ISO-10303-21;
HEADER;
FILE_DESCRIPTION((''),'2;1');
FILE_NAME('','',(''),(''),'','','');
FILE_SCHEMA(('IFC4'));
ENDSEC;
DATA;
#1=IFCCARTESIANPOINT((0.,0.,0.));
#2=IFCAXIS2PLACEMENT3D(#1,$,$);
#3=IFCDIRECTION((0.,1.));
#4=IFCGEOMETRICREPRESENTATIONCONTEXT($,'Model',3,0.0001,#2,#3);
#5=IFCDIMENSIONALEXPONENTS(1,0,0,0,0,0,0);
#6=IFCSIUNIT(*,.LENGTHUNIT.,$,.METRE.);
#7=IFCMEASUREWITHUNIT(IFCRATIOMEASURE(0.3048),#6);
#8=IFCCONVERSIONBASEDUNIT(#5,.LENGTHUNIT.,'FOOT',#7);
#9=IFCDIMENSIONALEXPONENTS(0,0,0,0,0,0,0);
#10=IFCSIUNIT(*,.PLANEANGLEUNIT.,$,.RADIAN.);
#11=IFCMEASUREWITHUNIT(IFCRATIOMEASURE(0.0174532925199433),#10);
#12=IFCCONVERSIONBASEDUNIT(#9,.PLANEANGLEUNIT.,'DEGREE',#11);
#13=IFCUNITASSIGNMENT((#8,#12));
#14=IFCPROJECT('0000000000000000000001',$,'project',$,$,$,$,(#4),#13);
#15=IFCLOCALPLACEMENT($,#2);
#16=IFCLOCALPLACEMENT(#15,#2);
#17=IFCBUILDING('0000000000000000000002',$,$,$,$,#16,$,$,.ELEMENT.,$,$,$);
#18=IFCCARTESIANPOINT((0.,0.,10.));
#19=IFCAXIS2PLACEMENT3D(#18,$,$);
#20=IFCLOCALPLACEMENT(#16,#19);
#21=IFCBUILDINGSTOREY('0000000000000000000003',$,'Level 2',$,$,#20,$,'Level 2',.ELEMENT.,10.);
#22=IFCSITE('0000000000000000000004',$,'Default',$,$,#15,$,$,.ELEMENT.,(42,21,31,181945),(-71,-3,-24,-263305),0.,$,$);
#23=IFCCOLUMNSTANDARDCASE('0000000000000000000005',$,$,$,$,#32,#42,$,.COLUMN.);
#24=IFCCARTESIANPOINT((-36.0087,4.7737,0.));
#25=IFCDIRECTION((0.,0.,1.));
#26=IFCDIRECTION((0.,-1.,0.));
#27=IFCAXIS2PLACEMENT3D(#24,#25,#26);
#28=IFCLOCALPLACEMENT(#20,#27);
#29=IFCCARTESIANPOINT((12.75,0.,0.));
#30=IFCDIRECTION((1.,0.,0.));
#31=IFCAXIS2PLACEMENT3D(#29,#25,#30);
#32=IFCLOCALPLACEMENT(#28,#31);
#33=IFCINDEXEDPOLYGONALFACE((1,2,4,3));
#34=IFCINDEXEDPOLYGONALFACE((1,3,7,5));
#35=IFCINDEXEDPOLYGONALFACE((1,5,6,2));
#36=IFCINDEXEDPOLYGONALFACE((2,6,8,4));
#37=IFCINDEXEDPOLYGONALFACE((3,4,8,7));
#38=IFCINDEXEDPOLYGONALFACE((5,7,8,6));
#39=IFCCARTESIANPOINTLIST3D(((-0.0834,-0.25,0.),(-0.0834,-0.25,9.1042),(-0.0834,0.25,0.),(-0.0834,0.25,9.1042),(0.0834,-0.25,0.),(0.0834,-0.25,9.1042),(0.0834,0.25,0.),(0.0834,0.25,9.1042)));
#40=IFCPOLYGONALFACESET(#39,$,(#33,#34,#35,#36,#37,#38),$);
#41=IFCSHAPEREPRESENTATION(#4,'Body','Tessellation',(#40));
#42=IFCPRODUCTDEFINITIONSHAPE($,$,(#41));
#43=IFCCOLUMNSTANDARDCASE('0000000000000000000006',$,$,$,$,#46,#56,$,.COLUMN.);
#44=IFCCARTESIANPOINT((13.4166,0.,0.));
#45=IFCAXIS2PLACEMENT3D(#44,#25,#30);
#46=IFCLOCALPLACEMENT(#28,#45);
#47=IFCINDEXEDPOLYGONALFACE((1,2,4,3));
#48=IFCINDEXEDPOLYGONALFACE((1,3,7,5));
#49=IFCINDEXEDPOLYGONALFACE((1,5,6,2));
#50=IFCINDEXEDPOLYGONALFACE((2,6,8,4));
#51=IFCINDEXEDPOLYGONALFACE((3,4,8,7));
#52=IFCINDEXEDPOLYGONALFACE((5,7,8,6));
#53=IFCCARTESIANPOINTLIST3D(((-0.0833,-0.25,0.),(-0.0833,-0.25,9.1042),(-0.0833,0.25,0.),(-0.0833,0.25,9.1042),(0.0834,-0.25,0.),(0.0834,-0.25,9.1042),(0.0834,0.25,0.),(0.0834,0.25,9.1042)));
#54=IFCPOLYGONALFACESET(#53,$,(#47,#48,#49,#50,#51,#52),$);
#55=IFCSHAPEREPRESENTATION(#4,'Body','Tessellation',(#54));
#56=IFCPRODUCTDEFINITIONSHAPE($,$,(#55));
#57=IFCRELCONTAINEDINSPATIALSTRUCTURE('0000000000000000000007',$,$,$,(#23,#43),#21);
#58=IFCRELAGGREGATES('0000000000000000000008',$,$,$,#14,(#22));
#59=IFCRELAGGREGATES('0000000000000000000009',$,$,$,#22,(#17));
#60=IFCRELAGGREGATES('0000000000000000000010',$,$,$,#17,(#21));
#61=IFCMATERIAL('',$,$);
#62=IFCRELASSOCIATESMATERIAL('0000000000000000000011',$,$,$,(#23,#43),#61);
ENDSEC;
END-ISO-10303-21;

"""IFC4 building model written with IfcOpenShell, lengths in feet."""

from ifc_helpers import new_model, entity, si_unit, converted_unit, direction, frame, origin, place, context, project, spatial, rectangle, extrude, material, element, save


model = new_model("IFC4")

# Units and contexts
model_context = context("Model", 3, precision=0.0001, world=origin(), true_north=direction((0.0, 1.0)))
ifc_project = project(units=[converted_unit("LENGTHUNIT", "FOOT", entity("IfcRatioMeasure", 0.3048), si_unit("LENGTHUNIT", "METRE"), dimensions=[1, 0, 0, 0, 0, 0, 0]), converted_unit("PLANEANGLEUNIT", "DEGREE", entity("IfcRatioMeasure", 0.0174532925199433), si_unit("PLANEANGLEUNIT", "RADIAN"), dimensions=[0, 0, 0, 0, 0, 0, 0])], contexts=[model_context])

# Site, building, storey
site_placement = place(None, origin())
site = spatial("IfcSite", under=ifc_project, at=site_placement, Name="Default", CompositionType="ELEMENT", RefLatitude=(42, 21, 31, 181945), RefLongitude=(-71, -3, -24, -263305), RefElevation=0.0)
building_placement = place(site_placement, origin())
building = spatial("IfcBuilding", under=site, at=building_placement, CompositionType="ELEMENT")
storey_placement = place(building_placement, frame((0.0, 0.0, 10.0)))
storey = spatial("IfcBuildingStorey", under=building, at=storey_placement, Name="Level 2", LongName="Level 2", CompositionType="ELEMENT", Elevation=10.0)

# Columns
ifc_material_1 = material(Name="")
placement = place(storey_placement, frame((-36.0087, 4.7737, 0.0), z_axis=(0.0, 0.0, 1.0), x_axis=(0.0, -1.0, 0.0)))
for number, where, z_axis, x_axis in (
    (1, (12.75, 0.0, 0.0), (0.0, 0.0, 1.0), (1.0, 0.0, 0.0)),
    (2, (13.4166, 0.0, 0.0), (0.0, 0.0, 1.0), (1.0, 0.0, 0.0)),
):
    element("IfcColumnStandardCase", number, at=place(placement, frame(where, z_axis=z_axis, x_axis=x_axis)), inside=storey, material=ifc_material_1, PredefinedType="COLUMN", context=model_context, shape_type="SweptSolid", body=[
        extrude(rectangle(XDim=0.1667, YDim=0.5), origin(), (0.0, 0.0, 1.0), 9.1042),
    ])

save(model, "model.ifc")
